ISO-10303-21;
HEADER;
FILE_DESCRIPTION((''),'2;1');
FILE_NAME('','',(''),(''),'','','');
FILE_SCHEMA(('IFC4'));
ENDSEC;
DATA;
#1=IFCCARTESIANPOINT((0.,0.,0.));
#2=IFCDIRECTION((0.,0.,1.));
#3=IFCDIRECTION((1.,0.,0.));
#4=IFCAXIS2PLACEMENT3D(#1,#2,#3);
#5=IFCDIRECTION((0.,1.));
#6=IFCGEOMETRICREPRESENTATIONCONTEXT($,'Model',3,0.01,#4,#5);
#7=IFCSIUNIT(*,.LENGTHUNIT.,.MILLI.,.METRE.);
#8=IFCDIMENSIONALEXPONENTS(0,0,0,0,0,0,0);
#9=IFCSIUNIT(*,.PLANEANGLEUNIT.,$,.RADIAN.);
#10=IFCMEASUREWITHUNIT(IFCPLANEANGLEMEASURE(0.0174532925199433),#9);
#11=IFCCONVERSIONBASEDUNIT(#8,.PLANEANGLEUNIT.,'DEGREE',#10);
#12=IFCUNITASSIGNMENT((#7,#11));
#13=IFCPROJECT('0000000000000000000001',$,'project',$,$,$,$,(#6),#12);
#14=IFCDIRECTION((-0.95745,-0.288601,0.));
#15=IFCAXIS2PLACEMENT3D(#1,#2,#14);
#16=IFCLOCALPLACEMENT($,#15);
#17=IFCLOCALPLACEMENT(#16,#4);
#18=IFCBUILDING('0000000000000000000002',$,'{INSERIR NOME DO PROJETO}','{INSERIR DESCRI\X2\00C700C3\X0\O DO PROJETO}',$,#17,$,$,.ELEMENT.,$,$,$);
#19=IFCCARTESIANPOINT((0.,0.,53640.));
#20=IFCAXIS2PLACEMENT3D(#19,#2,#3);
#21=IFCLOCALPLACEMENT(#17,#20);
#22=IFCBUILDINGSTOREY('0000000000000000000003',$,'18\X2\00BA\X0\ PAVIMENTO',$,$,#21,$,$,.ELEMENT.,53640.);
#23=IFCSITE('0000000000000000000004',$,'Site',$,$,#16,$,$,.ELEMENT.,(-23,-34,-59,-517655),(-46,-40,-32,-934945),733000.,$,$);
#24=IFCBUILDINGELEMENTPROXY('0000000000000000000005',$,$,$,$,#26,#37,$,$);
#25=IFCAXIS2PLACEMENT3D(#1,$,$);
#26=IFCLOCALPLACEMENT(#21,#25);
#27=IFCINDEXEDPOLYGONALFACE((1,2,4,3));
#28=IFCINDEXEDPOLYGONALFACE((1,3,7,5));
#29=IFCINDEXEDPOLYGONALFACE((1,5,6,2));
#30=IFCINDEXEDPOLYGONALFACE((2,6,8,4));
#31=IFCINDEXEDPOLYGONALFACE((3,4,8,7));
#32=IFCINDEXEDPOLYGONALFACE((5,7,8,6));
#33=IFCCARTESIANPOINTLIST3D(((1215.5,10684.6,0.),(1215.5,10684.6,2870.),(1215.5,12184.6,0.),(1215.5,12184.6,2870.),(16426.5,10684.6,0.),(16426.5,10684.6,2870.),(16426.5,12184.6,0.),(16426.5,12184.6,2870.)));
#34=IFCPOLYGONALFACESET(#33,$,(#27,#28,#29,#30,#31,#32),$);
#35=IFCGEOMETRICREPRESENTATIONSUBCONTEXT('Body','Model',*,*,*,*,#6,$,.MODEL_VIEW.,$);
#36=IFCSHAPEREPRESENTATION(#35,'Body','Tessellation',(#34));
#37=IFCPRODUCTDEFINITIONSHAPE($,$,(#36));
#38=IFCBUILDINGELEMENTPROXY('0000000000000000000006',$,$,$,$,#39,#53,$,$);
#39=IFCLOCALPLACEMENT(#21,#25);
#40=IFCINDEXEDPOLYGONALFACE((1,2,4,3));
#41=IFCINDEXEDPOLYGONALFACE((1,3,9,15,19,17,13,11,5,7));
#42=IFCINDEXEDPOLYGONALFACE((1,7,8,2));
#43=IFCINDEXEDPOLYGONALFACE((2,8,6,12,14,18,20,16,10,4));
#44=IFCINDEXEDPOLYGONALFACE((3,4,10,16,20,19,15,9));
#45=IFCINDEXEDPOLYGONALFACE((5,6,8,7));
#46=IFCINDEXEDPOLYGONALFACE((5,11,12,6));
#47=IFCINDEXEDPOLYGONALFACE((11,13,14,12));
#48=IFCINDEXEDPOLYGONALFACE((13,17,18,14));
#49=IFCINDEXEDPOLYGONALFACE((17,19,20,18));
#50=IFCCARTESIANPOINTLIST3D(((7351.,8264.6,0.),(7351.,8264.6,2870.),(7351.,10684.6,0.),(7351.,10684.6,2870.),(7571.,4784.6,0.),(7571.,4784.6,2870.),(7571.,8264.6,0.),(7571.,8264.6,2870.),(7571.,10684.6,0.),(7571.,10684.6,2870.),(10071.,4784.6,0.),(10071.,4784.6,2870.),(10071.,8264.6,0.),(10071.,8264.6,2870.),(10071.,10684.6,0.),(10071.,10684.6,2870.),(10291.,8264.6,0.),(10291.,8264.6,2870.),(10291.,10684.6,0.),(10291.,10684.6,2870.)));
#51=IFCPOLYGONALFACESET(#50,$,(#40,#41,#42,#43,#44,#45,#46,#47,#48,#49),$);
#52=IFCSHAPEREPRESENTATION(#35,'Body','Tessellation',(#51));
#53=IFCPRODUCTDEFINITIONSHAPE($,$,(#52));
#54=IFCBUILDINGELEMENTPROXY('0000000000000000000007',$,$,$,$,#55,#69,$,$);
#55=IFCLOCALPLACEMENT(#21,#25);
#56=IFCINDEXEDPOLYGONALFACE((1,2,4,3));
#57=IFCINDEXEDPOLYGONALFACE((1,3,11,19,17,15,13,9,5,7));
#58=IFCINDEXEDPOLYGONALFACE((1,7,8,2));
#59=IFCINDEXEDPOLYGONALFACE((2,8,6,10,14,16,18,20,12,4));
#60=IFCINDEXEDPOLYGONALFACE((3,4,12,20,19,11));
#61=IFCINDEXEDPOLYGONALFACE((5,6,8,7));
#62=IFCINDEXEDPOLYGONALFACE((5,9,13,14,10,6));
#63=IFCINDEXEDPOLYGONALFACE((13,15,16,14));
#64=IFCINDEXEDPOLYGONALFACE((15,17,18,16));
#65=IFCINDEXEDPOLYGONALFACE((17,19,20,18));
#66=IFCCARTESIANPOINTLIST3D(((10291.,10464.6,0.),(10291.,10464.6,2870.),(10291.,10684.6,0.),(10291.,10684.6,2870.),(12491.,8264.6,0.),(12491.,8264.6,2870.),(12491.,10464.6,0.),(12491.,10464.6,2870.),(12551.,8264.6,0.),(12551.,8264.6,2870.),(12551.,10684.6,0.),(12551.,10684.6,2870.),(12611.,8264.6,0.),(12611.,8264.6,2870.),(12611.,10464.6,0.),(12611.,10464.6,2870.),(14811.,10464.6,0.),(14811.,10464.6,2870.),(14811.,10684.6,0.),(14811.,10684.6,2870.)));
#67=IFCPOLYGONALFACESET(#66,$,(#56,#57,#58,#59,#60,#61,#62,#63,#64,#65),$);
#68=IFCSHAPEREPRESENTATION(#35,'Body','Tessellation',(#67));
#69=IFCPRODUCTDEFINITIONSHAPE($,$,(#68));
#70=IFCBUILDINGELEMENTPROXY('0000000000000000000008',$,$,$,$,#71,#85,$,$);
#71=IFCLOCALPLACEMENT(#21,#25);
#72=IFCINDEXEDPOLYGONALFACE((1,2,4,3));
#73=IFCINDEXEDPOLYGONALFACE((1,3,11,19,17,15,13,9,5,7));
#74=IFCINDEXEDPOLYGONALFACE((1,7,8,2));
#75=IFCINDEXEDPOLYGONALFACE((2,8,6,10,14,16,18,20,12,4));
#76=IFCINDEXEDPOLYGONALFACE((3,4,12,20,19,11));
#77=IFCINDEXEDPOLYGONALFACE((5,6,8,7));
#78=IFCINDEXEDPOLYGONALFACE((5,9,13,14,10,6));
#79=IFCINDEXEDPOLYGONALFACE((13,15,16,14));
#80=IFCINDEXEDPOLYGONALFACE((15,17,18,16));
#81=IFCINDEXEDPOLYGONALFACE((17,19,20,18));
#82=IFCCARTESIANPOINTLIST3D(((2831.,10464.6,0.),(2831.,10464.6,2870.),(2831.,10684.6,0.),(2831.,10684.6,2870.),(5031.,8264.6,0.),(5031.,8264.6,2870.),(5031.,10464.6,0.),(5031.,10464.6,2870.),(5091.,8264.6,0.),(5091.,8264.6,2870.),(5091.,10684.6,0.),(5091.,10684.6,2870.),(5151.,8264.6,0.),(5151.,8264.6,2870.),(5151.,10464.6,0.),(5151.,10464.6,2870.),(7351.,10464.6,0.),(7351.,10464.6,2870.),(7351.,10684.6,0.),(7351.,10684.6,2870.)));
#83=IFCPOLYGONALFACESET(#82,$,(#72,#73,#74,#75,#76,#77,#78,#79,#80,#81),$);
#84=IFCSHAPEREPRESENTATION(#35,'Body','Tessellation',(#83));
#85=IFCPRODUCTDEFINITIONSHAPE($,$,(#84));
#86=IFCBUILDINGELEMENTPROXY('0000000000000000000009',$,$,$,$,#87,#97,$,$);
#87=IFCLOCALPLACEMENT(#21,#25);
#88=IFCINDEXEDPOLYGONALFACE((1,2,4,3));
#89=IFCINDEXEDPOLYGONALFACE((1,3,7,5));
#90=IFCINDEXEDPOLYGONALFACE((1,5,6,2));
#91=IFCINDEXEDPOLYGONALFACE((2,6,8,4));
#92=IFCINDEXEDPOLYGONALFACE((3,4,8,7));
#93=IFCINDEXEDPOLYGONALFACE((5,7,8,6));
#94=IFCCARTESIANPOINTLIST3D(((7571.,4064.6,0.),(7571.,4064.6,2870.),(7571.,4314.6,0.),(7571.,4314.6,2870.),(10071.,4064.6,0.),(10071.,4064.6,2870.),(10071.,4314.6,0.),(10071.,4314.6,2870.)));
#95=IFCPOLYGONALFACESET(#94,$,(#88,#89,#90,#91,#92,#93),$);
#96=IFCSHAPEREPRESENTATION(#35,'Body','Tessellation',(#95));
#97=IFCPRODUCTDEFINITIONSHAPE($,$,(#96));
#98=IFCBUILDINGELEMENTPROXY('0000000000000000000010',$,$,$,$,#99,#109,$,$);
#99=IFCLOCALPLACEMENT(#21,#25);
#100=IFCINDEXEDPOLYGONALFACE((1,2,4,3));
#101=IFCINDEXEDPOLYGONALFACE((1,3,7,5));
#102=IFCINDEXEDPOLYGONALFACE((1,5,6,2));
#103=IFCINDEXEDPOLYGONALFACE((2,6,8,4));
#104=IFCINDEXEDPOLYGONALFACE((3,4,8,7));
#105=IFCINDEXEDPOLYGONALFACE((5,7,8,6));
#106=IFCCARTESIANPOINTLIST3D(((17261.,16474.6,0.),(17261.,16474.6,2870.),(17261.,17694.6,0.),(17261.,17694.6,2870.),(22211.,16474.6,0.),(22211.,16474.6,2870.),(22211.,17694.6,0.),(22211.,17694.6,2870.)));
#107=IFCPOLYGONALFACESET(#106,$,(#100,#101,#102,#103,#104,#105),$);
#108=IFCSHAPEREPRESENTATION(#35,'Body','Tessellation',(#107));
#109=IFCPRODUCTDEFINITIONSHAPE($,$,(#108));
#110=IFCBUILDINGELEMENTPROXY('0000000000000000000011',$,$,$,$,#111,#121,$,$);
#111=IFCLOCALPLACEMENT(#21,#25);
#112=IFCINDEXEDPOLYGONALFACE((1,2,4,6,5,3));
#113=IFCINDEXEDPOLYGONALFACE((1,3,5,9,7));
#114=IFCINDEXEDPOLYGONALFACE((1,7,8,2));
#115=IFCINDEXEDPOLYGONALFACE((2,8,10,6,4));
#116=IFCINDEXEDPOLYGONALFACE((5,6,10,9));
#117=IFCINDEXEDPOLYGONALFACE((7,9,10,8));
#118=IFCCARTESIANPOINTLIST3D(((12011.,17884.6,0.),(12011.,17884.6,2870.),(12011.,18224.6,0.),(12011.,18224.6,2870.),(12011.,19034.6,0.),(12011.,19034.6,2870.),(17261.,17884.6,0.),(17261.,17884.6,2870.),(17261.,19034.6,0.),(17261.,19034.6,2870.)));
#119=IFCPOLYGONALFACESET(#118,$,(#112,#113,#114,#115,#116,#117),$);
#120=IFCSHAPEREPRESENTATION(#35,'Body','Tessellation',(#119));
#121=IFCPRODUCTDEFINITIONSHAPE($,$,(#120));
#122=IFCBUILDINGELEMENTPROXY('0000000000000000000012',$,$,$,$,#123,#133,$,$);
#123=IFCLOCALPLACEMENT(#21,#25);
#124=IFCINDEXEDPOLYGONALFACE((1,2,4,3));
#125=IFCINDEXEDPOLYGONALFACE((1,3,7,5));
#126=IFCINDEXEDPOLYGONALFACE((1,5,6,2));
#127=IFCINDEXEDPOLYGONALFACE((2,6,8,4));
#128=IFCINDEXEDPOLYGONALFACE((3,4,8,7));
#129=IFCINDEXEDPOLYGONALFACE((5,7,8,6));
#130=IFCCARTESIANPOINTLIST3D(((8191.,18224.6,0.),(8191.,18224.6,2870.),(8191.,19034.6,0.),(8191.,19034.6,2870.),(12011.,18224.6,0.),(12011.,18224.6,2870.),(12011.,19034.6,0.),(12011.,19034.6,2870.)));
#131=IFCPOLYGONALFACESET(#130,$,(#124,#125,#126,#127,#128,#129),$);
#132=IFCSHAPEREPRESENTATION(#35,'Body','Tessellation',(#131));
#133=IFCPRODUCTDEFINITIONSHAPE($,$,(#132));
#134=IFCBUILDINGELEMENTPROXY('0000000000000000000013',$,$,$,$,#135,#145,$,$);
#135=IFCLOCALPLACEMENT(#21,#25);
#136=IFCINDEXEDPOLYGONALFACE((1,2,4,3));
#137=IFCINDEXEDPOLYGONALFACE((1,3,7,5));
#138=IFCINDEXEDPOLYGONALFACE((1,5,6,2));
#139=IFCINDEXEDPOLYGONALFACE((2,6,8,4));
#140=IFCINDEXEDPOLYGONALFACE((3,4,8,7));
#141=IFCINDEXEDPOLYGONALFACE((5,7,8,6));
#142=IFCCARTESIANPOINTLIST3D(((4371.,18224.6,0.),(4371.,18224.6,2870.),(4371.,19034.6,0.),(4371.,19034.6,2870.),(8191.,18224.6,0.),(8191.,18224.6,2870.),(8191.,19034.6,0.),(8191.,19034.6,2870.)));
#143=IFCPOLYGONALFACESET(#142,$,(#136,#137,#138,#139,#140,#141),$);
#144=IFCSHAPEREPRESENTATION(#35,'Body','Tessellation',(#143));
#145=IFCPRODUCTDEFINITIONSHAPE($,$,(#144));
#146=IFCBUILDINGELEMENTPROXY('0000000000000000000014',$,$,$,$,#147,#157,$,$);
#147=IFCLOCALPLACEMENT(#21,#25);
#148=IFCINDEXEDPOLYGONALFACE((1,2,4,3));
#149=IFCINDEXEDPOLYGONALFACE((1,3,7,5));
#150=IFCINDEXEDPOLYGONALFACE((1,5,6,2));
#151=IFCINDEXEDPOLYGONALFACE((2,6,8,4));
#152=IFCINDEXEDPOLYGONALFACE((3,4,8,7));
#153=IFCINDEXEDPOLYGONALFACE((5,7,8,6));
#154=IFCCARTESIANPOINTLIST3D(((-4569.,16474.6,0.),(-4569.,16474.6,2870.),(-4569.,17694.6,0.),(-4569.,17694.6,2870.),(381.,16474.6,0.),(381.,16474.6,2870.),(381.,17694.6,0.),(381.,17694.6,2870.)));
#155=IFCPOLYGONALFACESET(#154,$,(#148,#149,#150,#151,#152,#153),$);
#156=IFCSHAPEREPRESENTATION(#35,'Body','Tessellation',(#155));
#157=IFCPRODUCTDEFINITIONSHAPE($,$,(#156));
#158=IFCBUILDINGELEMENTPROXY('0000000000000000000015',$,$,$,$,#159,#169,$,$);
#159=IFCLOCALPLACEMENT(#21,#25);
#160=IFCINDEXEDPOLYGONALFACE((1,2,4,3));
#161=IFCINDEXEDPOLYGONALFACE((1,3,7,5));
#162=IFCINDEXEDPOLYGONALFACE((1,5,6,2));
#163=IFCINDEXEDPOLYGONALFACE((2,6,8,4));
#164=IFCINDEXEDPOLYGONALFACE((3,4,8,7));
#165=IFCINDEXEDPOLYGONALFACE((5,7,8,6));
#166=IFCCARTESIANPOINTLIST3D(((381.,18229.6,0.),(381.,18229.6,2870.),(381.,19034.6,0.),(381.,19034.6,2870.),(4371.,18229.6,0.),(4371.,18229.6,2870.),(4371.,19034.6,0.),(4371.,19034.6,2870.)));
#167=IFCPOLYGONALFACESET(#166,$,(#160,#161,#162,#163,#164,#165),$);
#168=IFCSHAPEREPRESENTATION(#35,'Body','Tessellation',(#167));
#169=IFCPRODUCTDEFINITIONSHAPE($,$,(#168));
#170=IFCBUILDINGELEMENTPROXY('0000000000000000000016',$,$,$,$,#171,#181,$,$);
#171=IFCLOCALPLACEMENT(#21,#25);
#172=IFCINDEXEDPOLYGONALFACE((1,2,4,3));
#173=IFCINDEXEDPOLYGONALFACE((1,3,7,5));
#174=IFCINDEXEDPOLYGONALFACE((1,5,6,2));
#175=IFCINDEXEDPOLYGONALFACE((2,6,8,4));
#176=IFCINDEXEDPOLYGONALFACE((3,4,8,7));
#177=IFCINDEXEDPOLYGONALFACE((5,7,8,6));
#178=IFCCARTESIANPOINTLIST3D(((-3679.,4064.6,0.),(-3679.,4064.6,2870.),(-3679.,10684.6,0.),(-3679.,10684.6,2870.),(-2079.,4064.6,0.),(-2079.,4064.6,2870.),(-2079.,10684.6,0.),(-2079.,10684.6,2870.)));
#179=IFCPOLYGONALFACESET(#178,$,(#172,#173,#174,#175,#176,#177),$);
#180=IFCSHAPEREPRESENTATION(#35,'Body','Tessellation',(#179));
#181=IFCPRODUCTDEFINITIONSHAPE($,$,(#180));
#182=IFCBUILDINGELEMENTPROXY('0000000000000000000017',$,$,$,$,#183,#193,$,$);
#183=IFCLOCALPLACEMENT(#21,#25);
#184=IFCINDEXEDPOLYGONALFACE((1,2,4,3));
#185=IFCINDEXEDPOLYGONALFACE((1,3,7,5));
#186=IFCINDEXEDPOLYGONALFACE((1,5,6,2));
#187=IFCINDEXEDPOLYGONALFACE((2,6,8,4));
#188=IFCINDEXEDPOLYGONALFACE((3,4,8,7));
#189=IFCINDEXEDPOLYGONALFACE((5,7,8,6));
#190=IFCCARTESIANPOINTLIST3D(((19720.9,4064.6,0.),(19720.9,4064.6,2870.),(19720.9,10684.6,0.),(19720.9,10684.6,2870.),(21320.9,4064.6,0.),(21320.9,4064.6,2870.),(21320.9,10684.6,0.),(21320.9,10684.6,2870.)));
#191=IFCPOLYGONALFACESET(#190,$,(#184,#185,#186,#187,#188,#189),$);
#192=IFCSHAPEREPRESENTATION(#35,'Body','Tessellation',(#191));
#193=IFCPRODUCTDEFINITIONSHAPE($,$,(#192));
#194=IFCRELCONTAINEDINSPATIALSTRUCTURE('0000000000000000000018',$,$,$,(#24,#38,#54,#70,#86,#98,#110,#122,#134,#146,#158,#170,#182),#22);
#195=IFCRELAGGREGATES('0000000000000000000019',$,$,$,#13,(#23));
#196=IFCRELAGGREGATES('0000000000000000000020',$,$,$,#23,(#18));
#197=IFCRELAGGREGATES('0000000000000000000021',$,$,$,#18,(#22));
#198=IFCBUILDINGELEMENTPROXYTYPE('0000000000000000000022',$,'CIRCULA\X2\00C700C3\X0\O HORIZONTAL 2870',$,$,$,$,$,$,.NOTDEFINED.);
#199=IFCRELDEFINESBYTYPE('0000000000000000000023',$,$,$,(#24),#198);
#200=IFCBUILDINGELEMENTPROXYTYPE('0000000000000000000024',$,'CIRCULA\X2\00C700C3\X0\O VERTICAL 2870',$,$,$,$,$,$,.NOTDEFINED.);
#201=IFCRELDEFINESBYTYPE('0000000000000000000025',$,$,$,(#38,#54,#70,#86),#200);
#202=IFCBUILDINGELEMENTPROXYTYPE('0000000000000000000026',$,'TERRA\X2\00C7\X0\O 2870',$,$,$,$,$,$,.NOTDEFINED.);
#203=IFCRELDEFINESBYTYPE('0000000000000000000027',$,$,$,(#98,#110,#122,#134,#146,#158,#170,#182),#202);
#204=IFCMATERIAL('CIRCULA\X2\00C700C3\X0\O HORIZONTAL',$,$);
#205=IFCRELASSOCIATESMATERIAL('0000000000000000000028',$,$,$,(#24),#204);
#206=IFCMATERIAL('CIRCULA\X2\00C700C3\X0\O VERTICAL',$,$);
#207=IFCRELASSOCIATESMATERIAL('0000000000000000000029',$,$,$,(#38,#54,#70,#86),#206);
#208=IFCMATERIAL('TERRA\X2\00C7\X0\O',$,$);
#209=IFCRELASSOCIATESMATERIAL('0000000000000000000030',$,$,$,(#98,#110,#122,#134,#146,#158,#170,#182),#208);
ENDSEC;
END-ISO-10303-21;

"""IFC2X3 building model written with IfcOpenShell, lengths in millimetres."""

from ifc_helpers import new_model, entity, si_unit, converted_unit, direction, frame, origin_with_axes, place, context, subcontext, project, spatial, polyline, outline, extrude, material, type_object, element, save


model = new_model("IFC2X3")

# Units and contexts
model_context = context("Model", 3, precision=0.01, world=origin_with_axes(), true_north=direction((0.0, 1.0)))
body_context = subcontext(model_context, "Body", "Model", "MODEL_VIEW")
ifc_project = project(units=[si_unit("LENGTHUNIT", "METRE", prefix="MILLI"), converted_unit("PLANEANGLEUNIT", "DEGREE", entity("IfcPlaneAngleMeasure", 0.0174532925199433), si_unit("PLANEANGLEUNIT", "RADIAN"), dimensions=[0, 0, 0, 0, 0, 0, 0])], contexts=[model_context])

# Site, building, storey
site_placement = place(None, frame((0.0, 0.0, 0.0), z_axis=(0.0, 0.0, 1.0), x_axis=(-0.95745, -0.288601, 0.0)))
site = spatial("IfcSite", under=ifc_project, at=site_placement, Name="Site", CompositionType="ELEMENT", RefLatitude=(-23, -34, -59, -517655), RefLongitude=(-46, -40, -32, -934945), RefElevation=733000.0)
building_placement = place(site_placement, origin_with_axes())
building = spatial("IfcBuilding", under=site, at=building_placement, Name="{INSERIR NOME DO PROJETO}", Description="{INSERIR DESCRIÇÃO DO PROJETO}", CompositionType="ELEMENT")
storey_placement = place(building_placement, frame((0.0, 0.0, 53640.0), z_axis=(0.0, 0.0, 1.0), x_axis=(1.0, 0.0, 0.0)))
storey = spatial("IfcBuildingStorey", under=building, at=storey_placement, Name="18º PAVIMENTO", CompositionType="ELEMENT", Elevation=53640.0)

# Building element proxies
ifc_material_1 = material(Name="CIRCULAÇÃO HORIZONTAL")
building_element_proxy_type_1 = type_object("IfcBuildingElementProxyType", Name="CIRCULAÇÃO HORIZONTAL 2870", PredefinedType="NOTDEFINED")
proxy_1_placement = place(storey_placement, frame((1215.5, 10684.6, 0.0), z_axis=(0.0, 0.0, 1.0), x_axis=(1.0, 0.0, 0.0)))
element("IfcBuildingElementProxy", 1, at=proxy_1_placement, inside=storey, type_object=building_element_proxy_type_1, material=ifc_material_1, context=body_context, shape_type="SweptSolid", body=[
    extrude(outline(polyline([(0.0, 0.0), (15211.0, 0.0), (15211.0, 1500.0), (0.0, 1500.0), (0.0, 0.0)])), origin_with_axes(), (0.0, 0.0, 1.0), 2870.0),
])
ifc_material_2 = material(Name="CIRCULAÇÃO VERTICAL")
building_element_proxy_type_2 = type_object("IfcBuildingElementProxyType", Name="CIRCULAÇÃO VERTICAL 2870", PredefinedType="NOTDEFINED")
proxy_2_placement = place(storey_placement, frame((7351.0, 10684.6, 0.0), z_axis=(0.0, 0.0, 1.0), x_axis=(1.0, 0.0, 0.0)))
element("IfcBuildingElementProxy", 2, at=proxy_2_placement, inside=storey, type_object=building_element_proxy_type_2, material=ifc_material_2, context=body_context, shape_type="SweptSolid", body=[
    extrude(outline(polyline([(0.0, 0.0), (0.0, -2420.0), (220.0, -2420.0), (220.0, -5900.0), (2720.0, -5900.0), (2720.0, -2420.0), (2940.0, -2420.0), (2940.0, 0.0), (2720.0, 0.0), (220.0, 0.0), (0.0, 0.0)])), origin_with_axes(), (0.0, 0.0, 1.0), 2870.0),
])
proxy_3_placement = place(storey_placement, frame((10291.0, 10684.6, 0.0), z_axis=(0.0, 0.0, 1.0), x_axis=(1.0, 0.0, 0.0)))
element("IfcBuildingElementProxy", 3, at=proxy_3_placement, inside=storey, type_object=building_element_proxy_type_2, material=ifc_material_2, context=body_context, shape_type="SweptSolid", body=[
    extrude(outline(polyline([(0.0, 0.0), (0.0, -220.0), (2200.0, -220.0), (2200.0, -2420.0), (2260.0, -2420.0), (2320.0, -2420.0), (2320.0, -220.0), (4520.0, -220.0), (4520.0, 0.0), (2260.0, 0.0), (0.0, 0.0)])), origin_with_axes(), (0.0, 0.0, 1.0), 2870.0),
])
proxy_4_placement = place(storey_placement, frame((5091.0, 10684.6, 0.0), z_axis=(0.0, 0.0, 1.0), x_axis=(1.0, 0.0, 0.0)))
element("IfcBuildingElementProxy", 4, at=proxy_4_placement, inside=storey, type_object=building_element_proxy_type_2, material=ifc_material_2, context=body_context, shape_type="SweptSolid", body=[
    extrude(outline(polyline([(0.0, 0.0), (-2260.0, 0.0), (-2260.0, -220.0), (-60.0, -220.0), (-60.0, -2420.0), (0.0, -2420.0), (60.0, -2420.0), (60.0, -220.0), (2260.0, -220.0), (2260.0, 0.0), (0.0, 0.0)])), origin_with_axes(), (0.0, 0.0, 1.0), 2870.0),
])
proxy_5_placement = place(storey_placement, frame((7571.0, 4064.6, 0.0), z_axis=(0.0, 0.0, 1.0), x_axis=(1.0, 0.0, 0.0)))
element("IfcBuildingElementProxy", 5, at=proxy_5_placement, inside=storey, type_object=building_element_proxy_type_2, material=ifc_material_2, context=body_context, shape_type="SweptSolid", body=[
    extrude(outline(polyline([(0.0, 0.0), (2500.0, 0.0), (2500.0, 250.0), (0.0, 250.0), (0.0, 0.0)])), origin_with_axes(), (0.0, 0.0, 1.0), 2870.0),
])
ifc_material_3 = material(Name="TERRAÇO")
building_element_proxy_type_3 = type_object("IfcBuildingElementProxyType", Name="TERRAÇO 2870", PredefinedType="NOTDEFINED")
proxy_6_placement = place(storey_placement, frame((17261.0, 16474.6, 0.0), z_axis=(0.0, 0.0, 1.0), x_axis=(1.0, 0.0, 0.0)))
element("IfcBuildingElementProxy", 6, at=proxy_6_placement, inside=storey, type_object=building_element_proxy_type_3, material=ifc_material_3, context=body_context, shape_type="SweptSolid", body=[
    extrude(outline(polyline([(0.0, 0.0), (4950.0, 0.0), (4950.0, 1220.0), (0.0, 1220.0), (0.0, 0.0)])), origin_with_axes(), (0.0, 0.0, 1.0), 2870.0),
])
proxy_7_placement = place(storey_placement, frame((12011.0, 19034.6, 0.0), z_axis=(0.0, 0.0, 1.0), x_axis=(1.0, 0.0, 0.0)))
element("IfcBuildingElementProxy", 7, at=proxy_7_placement, inside=storey, type_object=building_element_proxy_type_3, material=ifc_material_3, context=body_context, shape_type="SweptSolid", body=[
    extrude(outline(polyline([(0.0, 0.0), (0.0, -810.0), (0.0, -1150.0), (5250.0, -1150.0), (5250.0, 0.0), (0.0, 0.0)])), origin_with_axes(), (0.0, 0.0, 1.0), 2870.0),
])
for number, where, z_axis, x_axis in (
    (8, (8191.0, 18224.6, 0.0), (0.0, 0.0, 1.0), (1.0, 0.0, 0.0)),
    (9, (4371.0, 18224.6, 0.0), (0.0, 0.0, 1.0), (1.0, 0.0, 0.0)),
):
    element("IfcBuildingElementProxy", number, at=place(storey_placement, frame(where, z_axis=z_axis, x_axis=x_axis)), inside=storey, type_object=building_element_proxy_type_3, material=ifc_material_3, context=body_context, shape_type="SweptSolid", body=[
        extrude(outline(polyline([(0.0, 0.0), (3820.0, 0.0), (3820.0, 810.0), (0.0, 810.0), (0.0, 0.0)])), origin_with_axes(), (0.0, 0.0, 1.0), 2870.0),
    ])
proxy_8_placement = place(storey_placement, frame((381.0, 17694.6, 0.0), z_axis=(0.0, 0.0, 1.0), x_axis=(1.0, 0.0, 0.0)))
element("IfcBuildingElementProxy", 10, at=proxy_8_placement, inside=storey, type_object=building_element_proxy_type_3, material=ifc_material_3, context=body_context, shape_type="SweptSolid", body=[
    extrude(outline(polyline([(0.0, 0.0), (-4950.0, 0.0), (-4950.0, -1220.0), (0.0, -1220.0), (0.0, 0.0)])), origin_with_axes(), (0.0, 0.0, 1.0), 2870.0),
])
proxy_9_placement = place(storey_placement, frame((381.0, 19034.6, 0.0), z_axis=(0.0, 0.0, 1.0), x_axis=(1.0, 0.0, 0.0)))
element("IfcBuildingElementProxy", 11, at=proxy_9_placement, inside=storey, type_object=building_element_proxy_type_3, material=ifc_material_3, context=body_context, shape_type="SweptSolid", body=[
    extrude(outline(polyline([(0.0, 0.0), (0.0, -805.0), (3990.0, -805.0), (3990.0, 0.0), (0.0, 0.0)])), origin_with_axes(), (0.0, 0.0, 1.0), 2870.0),
])
proxy_10_placement = place(storey_placement, frame((-3679.0, 4064.6, 0.0), z_axis=(0.0, 0.0, 1.0), x_axis=(1.0, 0.0, 0.0)))
element("IfcBuildingElementProxy", 12, at=proxy_10_placement, inside=storey, type_object=building_element_proxy_type_3, material=ifc_material_3, context=body_context, shape_type="SweptSolid", body=[
    extrude(outline(polyline([(0.0, 0.0), (1600.0, 0.0), (1600.0, 6620.0), (0.0, 6620.0), (0.0, 0.0)])), origin_with_axes(), (0.0, 0.0, 1.0), 2870.0),
])
proxy_11_placement = place(storey_placement, frame((21320.9, 4064.6, 0.0), z_axis=(0.0, 0.0, 1.0), x_axis=(1.0, 0.0, 0.0)))
element("IfcBuildingElementProxy", 13, at=proxy_11_placement, inside=storey, type_object=building_element_proxy_type_3, material=ifc_material_3, context=body_context, shape_type="SweptSolid", body=[
    extrude(outline(polyline([(0.0, 0.0), (0.0, 6620.0), (-1600.0, 6620.0), (-1600.0, 0.0), (0.0, 0.0)])), origin_with_axes(), (0.0, 0.0, 1.0), 2870.0),
])

save(model, "model.ifc")
